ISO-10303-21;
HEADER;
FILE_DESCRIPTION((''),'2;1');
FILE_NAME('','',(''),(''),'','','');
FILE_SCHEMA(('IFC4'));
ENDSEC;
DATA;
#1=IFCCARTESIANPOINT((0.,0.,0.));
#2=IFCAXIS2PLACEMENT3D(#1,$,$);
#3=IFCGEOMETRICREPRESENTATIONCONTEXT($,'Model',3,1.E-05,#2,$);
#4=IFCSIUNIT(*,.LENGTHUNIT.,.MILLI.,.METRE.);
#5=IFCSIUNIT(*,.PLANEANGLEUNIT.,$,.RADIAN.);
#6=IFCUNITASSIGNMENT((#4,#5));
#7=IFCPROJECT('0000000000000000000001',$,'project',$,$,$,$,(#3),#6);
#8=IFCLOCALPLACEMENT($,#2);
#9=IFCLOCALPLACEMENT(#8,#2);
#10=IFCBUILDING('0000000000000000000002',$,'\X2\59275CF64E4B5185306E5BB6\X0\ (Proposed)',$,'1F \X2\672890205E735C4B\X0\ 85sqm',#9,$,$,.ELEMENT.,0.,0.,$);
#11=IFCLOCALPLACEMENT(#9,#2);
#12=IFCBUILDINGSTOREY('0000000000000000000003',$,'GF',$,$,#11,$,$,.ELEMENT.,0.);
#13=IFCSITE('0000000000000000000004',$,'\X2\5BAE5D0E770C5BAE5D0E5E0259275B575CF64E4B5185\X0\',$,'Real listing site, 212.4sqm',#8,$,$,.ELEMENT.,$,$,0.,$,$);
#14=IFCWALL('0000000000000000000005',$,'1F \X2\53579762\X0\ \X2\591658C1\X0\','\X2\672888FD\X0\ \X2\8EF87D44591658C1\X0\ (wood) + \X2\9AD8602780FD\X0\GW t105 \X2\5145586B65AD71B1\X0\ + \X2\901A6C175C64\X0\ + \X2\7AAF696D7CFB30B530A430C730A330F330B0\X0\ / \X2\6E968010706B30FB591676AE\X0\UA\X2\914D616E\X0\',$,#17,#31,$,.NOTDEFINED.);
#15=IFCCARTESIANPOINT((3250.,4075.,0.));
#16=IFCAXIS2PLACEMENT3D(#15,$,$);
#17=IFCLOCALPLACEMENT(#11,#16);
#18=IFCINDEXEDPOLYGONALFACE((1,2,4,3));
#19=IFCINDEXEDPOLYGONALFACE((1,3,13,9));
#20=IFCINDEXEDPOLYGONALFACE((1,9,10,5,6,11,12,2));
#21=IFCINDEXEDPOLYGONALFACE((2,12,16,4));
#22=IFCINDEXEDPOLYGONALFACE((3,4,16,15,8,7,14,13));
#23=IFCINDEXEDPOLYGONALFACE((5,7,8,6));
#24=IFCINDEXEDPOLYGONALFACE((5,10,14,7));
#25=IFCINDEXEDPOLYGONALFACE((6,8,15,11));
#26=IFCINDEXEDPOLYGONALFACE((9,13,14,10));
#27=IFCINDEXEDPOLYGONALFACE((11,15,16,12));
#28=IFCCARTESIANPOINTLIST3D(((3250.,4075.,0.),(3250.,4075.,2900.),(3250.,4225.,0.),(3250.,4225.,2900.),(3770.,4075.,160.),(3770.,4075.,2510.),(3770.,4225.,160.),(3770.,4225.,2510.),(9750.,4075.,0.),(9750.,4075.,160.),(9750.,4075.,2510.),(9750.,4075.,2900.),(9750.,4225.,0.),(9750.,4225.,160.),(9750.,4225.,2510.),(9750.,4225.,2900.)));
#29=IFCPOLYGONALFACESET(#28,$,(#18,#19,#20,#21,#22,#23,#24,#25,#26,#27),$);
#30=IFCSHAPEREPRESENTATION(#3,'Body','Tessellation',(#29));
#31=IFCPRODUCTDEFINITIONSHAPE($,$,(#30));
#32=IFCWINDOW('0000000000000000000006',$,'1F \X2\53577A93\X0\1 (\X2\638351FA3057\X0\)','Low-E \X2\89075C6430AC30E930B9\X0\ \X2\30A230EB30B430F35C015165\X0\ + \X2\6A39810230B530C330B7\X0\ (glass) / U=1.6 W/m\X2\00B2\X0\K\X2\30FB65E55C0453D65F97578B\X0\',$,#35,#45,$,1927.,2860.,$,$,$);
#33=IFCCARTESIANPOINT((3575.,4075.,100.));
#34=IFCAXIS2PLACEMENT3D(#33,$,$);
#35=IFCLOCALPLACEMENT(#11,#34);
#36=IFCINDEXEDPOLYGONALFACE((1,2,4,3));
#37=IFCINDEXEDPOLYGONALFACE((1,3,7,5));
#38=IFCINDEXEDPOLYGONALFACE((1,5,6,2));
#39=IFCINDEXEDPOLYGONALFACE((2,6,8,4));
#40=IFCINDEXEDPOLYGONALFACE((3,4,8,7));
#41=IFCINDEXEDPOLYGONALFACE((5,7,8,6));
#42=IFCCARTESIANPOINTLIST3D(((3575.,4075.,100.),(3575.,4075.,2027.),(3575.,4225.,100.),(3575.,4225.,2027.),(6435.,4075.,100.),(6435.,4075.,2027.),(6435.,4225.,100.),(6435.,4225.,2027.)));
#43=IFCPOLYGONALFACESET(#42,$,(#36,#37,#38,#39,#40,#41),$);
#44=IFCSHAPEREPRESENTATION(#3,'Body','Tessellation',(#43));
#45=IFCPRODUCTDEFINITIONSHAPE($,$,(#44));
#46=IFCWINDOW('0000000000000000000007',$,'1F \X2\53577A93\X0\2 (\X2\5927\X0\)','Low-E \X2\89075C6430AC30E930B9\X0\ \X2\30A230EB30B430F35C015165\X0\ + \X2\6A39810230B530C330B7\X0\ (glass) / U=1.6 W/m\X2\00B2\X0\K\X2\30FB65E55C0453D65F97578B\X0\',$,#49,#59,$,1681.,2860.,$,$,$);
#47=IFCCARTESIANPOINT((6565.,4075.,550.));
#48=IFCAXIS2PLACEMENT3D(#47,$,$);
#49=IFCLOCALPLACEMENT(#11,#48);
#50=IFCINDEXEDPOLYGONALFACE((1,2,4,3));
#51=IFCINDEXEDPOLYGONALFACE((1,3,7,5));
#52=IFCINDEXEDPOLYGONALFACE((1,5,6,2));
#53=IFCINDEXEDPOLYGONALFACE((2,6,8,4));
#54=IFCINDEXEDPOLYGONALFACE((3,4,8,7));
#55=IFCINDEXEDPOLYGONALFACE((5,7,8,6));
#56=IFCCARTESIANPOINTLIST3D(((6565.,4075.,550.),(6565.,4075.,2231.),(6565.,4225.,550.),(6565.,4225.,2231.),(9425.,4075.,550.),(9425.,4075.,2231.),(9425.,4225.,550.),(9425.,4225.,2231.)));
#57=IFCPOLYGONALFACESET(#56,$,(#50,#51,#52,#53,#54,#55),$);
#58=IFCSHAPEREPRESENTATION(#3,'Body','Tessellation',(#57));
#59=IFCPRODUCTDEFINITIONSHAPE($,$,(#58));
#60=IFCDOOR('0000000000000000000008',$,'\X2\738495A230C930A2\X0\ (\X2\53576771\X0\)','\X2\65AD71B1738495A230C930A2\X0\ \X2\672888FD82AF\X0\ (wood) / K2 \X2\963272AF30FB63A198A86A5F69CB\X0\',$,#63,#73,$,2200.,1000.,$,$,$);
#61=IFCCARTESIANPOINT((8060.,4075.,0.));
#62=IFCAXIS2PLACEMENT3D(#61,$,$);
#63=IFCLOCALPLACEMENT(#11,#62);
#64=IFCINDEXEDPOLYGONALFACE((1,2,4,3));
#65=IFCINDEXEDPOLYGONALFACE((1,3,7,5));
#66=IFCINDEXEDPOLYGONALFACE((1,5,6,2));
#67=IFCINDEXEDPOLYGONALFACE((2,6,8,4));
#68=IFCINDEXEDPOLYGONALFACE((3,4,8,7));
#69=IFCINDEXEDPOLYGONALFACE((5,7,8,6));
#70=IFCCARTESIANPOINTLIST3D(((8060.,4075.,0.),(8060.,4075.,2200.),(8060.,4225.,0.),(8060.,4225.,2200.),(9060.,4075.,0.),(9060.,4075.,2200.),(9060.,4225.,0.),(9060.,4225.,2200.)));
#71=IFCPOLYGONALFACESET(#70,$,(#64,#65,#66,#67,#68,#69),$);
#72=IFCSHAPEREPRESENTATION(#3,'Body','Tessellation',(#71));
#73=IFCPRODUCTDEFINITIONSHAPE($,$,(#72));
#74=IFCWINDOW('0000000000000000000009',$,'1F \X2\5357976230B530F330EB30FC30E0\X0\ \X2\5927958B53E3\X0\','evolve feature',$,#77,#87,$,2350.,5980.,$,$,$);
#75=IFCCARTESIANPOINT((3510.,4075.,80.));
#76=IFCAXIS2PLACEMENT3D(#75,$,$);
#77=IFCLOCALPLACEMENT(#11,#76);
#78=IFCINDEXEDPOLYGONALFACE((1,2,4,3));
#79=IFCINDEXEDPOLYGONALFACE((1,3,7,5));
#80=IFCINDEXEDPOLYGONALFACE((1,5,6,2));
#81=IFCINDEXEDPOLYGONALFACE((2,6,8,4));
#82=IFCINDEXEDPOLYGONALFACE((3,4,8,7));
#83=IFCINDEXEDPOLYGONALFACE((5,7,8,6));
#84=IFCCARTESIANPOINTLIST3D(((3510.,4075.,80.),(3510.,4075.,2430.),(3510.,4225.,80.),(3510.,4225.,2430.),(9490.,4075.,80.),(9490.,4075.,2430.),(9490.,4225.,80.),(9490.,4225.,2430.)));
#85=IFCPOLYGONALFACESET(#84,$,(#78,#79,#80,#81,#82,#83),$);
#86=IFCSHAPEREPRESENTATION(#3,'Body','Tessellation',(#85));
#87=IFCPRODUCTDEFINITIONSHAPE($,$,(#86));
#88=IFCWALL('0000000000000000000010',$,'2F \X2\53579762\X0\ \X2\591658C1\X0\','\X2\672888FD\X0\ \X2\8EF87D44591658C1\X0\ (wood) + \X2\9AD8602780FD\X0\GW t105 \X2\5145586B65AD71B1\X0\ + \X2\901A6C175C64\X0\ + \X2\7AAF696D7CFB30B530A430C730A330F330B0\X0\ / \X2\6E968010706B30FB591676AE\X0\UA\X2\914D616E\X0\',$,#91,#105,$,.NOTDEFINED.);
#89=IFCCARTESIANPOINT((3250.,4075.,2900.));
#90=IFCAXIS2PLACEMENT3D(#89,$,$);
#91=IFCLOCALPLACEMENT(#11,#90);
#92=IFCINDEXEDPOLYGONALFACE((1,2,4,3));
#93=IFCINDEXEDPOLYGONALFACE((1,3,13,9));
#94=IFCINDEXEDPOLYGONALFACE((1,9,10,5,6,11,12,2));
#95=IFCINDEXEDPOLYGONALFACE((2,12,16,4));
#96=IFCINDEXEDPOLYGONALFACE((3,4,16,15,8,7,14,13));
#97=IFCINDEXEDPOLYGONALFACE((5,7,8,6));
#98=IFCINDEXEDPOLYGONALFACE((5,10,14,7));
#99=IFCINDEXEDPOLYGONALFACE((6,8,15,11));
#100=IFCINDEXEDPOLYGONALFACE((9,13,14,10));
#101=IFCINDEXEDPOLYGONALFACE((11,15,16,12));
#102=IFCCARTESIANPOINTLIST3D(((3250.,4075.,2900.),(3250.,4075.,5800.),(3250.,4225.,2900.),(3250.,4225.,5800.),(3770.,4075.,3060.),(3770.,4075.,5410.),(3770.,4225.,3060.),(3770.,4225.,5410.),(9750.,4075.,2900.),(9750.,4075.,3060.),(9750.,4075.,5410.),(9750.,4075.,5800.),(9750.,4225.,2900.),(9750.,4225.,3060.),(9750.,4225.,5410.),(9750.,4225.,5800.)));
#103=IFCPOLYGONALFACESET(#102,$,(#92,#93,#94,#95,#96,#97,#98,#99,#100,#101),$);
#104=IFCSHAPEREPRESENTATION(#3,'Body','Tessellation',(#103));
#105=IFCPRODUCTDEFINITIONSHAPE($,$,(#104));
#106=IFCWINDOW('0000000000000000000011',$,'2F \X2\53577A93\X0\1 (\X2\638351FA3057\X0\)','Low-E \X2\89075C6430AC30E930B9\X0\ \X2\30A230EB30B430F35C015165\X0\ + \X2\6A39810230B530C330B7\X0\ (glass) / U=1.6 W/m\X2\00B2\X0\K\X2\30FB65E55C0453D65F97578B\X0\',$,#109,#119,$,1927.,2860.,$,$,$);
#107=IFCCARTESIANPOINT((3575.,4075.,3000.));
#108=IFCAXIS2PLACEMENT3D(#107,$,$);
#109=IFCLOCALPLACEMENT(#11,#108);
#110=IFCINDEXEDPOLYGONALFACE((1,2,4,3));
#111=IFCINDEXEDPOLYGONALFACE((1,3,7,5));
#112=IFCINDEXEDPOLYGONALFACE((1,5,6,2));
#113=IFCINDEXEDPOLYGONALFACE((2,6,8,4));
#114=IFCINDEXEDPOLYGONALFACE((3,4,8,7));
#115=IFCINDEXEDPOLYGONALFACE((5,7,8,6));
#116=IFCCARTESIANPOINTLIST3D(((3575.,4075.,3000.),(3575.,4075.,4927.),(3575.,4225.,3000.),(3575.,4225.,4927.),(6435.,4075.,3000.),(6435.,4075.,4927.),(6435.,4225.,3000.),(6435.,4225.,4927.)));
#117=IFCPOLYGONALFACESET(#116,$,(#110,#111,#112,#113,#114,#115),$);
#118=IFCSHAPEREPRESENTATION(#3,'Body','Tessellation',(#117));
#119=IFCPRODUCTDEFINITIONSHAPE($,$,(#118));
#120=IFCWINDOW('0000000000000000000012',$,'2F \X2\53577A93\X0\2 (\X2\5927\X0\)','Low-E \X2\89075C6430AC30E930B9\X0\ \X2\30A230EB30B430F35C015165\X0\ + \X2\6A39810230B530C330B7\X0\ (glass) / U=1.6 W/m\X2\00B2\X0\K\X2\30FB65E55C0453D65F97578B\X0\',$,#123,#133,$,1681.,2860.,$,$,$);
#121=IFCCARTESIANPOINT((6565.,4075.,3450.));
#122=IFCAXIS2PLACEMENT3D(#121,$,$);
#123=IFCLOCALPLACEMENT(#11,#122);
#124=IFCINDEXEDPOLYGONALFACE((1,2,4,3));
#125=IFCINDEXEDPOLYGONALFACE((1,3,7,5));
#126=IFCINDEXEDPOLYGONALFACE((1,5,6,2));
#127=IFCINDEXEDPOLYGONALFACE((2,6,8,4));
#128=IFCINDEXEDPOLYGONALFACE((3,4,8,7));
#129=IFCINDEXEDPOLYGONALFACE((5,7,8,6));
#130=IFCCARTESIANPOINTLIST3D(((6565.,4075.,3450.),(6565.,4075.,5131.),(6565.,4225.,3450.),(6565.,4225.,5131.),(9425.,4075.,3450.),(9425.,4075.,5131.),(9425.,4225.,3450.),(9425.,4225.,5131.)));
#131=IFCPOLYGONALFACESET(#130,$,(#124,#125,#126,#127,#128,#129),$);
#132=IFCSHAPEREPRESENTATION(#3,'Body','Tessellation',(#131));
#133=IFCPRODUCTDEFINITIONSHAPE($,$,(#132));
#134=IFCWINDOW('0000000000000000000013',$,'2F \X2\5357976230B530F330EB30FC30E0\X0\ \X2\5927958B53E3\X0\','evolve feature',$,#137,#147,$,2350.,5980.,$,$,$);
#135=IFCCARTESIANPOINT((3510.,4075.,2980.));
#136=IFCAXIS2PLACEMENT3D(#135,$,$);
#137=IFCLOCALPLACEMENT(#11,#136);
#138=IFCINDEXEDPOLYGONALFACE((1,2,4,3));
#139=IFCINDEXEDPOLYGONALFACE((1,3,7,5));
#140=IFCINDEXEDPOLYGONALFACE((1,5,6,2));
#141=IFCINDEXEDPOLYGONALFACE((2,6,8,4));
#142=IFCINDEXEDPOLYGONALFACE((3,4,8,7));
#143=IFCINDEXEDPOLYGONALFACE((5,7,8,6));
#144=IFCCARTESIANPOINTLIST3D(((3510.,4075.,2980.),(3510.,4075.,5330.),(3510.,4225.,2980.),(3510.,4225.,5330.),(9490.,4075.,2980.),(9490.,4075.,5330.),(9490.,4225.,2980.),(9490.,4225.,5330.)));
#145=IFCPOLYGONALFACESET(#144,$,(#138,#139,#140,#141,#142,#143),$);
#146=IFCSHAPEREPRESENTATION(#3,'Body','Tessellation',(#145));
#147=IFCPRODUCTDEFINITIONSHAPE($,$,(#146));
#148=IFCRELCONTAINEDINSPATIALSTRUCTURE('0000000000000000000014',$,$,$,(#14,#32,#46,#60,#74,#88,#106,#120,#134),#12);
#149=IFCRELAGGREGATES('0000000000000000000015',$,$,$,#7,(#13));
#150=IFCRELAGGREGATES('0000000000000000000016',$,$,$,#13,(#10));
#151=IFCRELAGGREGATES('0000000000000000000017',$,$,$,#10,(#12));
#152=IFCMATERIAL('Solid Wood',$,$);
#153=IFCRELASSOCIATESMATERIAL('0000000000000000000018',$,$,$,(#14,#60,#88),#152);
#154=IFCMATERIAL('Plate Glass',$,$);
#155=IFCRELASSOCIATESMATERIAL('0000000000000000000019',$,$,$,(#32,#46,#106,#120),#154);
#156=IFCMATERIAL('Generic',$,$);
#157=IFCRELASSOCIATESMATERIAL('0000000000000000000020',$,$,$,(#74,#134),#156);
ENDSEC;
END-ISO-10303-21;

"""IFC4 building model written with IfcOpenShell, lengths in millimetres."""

from ifc_helpers import new_model, si_unit, frame, frame_2d, origin, place, context, project, spatial, rectangle, extrude, material, element, fill, save


model = new_model("IFC4")

# Units and contexts
model_context = context("Model", 3, precision=1e-05, world=origin())
ifc_project = project(units=[si_unit("LENGTHUNIT", "METRE", prefix="MILLI"), si_unit("PLANEANGLEUNIT", "RADIAN")], contexts=[model_context])

# Site, building, storey
site_placement = place(None, origin())
site = spatial("IfcSite", under=ifc_project, at=site_placement, Name="宮崎県宮崎市大字島之内", ObjectType="Real listing site, 212.4sqm", CompositionType="ELEMENT", RefElevation=0.0)
building_placement = place(site_placement, origin())
building = spatial("IfcBuilding", under=site, at=building_placement, Name="大島之内の家 (Proposed)", ObjectType="1F 木造平屋 85sqm", CompositionType="ELEMENT", ElevationOfRefHeight=0.0, ElevationOfTerrain=0.0)
storey_placement = place(building_placement, origin())
storey = spatial("IfcBuildingStorey", under=building, at=storey_placement, Name="GF", CompositionType="ELEMENT", Elevation=0.0)

# Shared definitions
ifc_material_1 = material(Name="Solid Wood")
ifc_material_2 = material(Name="Generic")

# Wall, openings, windows, door
wall_1_placement = place(storey_placement, frame((3250.0, 4075.0, 0.0)))
wall_1 = element("IfcWall", 1, at=wall_1_placement, inside=storey, material=ifc_material_1, Name="1F 南面 外壁", Description="木製 軸組外壁 (wood) + 高性能GW t105 充填断熱 + 通気層 + 窯業系サイディング / 準耐火・外皮UA配慮", PredefinedType="NOTDEFINED", context=model_context, shape_type="SweptSolid", body=[
    extrude(rectangle(XDim=6500.0, YDim=150.0, at=frame_2d((3250.0, 75.0))), frame((3250.0, 4075.0, 0.0)), (0.0, 0.0, 1.0), 2900.0),
])
opening_1_placement = place(storey_placement, frame((3575.0, 4075.0, 100.0)))
opening_1 = element("IfcOpeningElement", 2, at=opening_1_placement, cuts=wall_1, PredefinedType="NOTDEFINED", context=model_context, shape_type="SweptSolid", body=[
    extrude(rectangle(XDim=2860.0, YDim=150.0, at=frame_2d((1430.0, 75.0))), frame((3575.0, 4075.0, 100.0)), (0.0, 0.0, 1.0), 1927.0),
])
opening_2_placement = place(storey_placement, frame((6565.0, 4075.0, 550.0)))
opening_2 = element("IfcOpeningElement", 3, at=opening_2_placement, cuts=wall_1, PredefinedType="NOTDEFINED", context=model_context, shape_type="SweptSolid", body=[
    extrude(rectangle(XDim=2860.0, YDim=150.0, at=frame_2d((1430.0, 75.0))), frame((6565.0, 4075.0, 550.0)), (0.0, 0.0, 1.0), 1681.0),
])
opening_3_placement = place(storey_placement, frame((8060.0, 4075.0, 0.0)))
opening_3 = element("IfcOpeningElement", 4, at=opening_3_placement, cuts=wall_1, PredefinedType="NOTDEFINED", context=model_context, shape_type="SweptSolid", body=[
    extrude(rectangle(XDim=1000.0, YDim=150.0, at=frame_2d((500.0, 75.0))), frame((8060.0, 4075.0, 0.0)), (0.0, 0.0, 1.0), 2200.0),
])
opening_4_placement = place(storey_placement, frame((3510.0, 4075.0, 80.0)))
opening_4 = element("IfcOpeningElement", 5, at=opening_4_placement, cuts=wall_1, PredefinedType="NOTDEFINED", context=model_context, shape_type="SweptSolid", body=[
    extrude(rectangle(XDim=5980.0, YDim=150.0, at=frame_2d((2990.0, 75.0))), frame((3510.0, 4075.0, 80.0)), (0.0, 0.0, 1.0), 2350.0),
])
ifc_material_3 = material(Name="Plate Glass")
window_1_placement = place(storey_placement, frame((3575.0, 4075.0, 100.0)))
window_1 = element("IfcWindow", 6, at=window_1_placement, inside=storey, material=ifc_material_3, Name="1F 南窓1 (掃出し)", Description="Low-E 複層ガラス アルゴン封入 + 樹脂サッシ (glass) / U=1.6 W/m²K・日射取得型", OverallHeight=1927.0, OverallWidth=2860.0, context=model_context, shape_type="SweptSolid", body=[
    extrude(rectangle(XDim=2860.0, YDim=150.0, at=frame_2d((1430.0, 75.0))), frame((3575.0, 4075.0, 100.0)), (0.0, 0.0, 1.0), 1927.0),
])
fill(opening_1, window_1)
window_2_placement = place(storey_placement, frame((6565.0, 4075.0, 550.0)))
window_2 = element("IfcWindow", 7, at=window_2_placement, inside=storey, material=ifc_material_3, Name="1F 南窓2 (大)", Description="Low-E 複層ガラス アルゴン封入 + 樹脂サッシ (glass) / U=1.6 W/m²K・日射取得型", OverallHeight=1681.0, OverallWidth=2860.0, context=model_context, shape_type="SweptSolid", body=[
    extrude(rectangle(XDim=2860.0, YDim=150.0, at=frame_2d((1430.0, 75.0))), frame((6565.0, 4075.0, 550.0)), (0.0, 0.0, 1.0), 1681.0),
])
fill(opening_2, window_2)
door_placement = place(storey_placement, frame((8060.0, 4075.0, 0.0)))
door = element("IfcDoor", 8, at=door_placement, inside=storey, material=ifc_material_1, Name="玄関ドア (南東)", Description="断熱玄関ドア 木製芯 (wood) / K2 防犯・採風機構", OverallHeight=2200.0, OverallWidth=1000.0, context=model_context, shape_type="SweptSolid", body=[
    extrude(rectangle(XDim=1000.0, YDim=150.0, at=frame_2d((500.0, 75.0))), frame((8060.0, 4075.0, 0.0)), (0.0, 0.0, 1.0), 2200.0),
])
fill(opening_3, door)
window_3_placement = place(storey_placement, frame((3510.0, 4075.0, 80.0)))
window_3 = element("IfcWindow", 9, at=window_3_placement, inside=storey, material=ifc_material_2, Name="1F 南面サンルーム 大開口", Description="evolve feature", OverallHeight=2350.0, OverallWidth=5980.0, context=model_context, shape_type="SweptSolid", body=[
    extrude(rectangle(XDim=5980.0, YDim=150.0, at=frame_2d((2990.0, 75.0))), frame((3510.0, 4075.0, 80.0)), (0.0, 0.0, 1.0), 2350.0),
])
fill(opening_4, window_3)

# Wall, openings, windows
wall_2_placement = place(storey_placement, frame((3250.0, 4075.0, 2900.0)))
wall_2 = element("IfcWall", 10, at=wall_2_placement, inside=storey, material=ifc_material_1, Name="2F 南面 外壁", Description="木製 軸組外壁 (wood) + 高性能GW t105 充填断熱 + 通気層 + 窯業系サイディング / 準耐火・外皮UA配慮", PredefinedType="NOTDEFINED", context=model_context, shape_type="SweptSolid", body=[
    extrude(rectangle(XDim=6500.0, YDim=150.0, at=frame_2d((3250.0, 75.0))), frame((3250.0, 4075.0, 2900.0)), (0.0, 0.0, 1.0), 2900.0),
])
opening_5_placement = place(storey_placement, frame((3575.0, 4075.0, 3000.0)))
opening_5 = element("IfcOpeningElement", 11, at=opening_5_placement, cuts=wall_2, PredefinedType="NOTDEFINED", context=model_context, shape_type="SweptSolid", body=[
    extrude(rectangle(XDim=2860.0, YDim=150.0, at=frame_2d((1430.0, 75.0))), frame((3575.0, 4075.0, 3000.0)), (0.0, 0.0, 1.0), 1927.0),
])
opening_6_placement = place(storey_placement, frame((6565.0, 4075.0, 3450.0)))
opening_6 = element("IfcOpeningElement", 12, at=opening_6_placement, cuts=wall_2, PredefinedType="NOTDEFINED", context=model_context, shape_type="SweptSolid", body=[
    extrude(rectangle(XDim=2860.0, YDim=150.0, at=frame_2d((1430.0, 75.0))), frame((6565.0, 4075.0, 3450.0)), (0.0, 0.0, 1.0), 1681.0),
])
opening_7_placement = place(storey_placement, frame((3510.0, 4075.0, 2980.0)))
opening_7 = element("IfcOpeningElement", 13, at=opening_7_placement, cuts=wall_2, PredefinedType="NOTDEFINED", context=model_context, shape_type="SweptSolid", body=[
    extrude(rectangle(XDim=5980.0, YDim=150.0, at=frame_2d((2990.0, 75.0))), frame((3510.0, 4075.0, 2980.0)), (0.0, 0.0, 1.0), 2350.0),
])
window_4_placement = place(storey_placement, frame((3575.0, 4075.0, 3000.0)))
window_4 = element("IfcWindow", 14, at=window_4_placement, inside=storey, material=ifc_material_3, Name="2F 南窓1 (掃出し)", Description="Low-E 複層ガラス アルゴン封入 + 樹脂サッシ (glass) / U=1.6 W/m²K・日射取得型", OverallHeight=1927.0, OverallWidth=2860.0, context=model_context, shape_type="SweptSolid", body=[
    extrude(rectangle(XDim=2860.0, YDim=150.0, at=frame_2d((1430.0, 75.0))), frame((3575.0, 4075.0, 3000.0)), (0.0, 0.0, 1.0), 1927.0),
])
fill(opening_5, window_4)
window_5_placement = place(storey_placement, frame((6565.0, 4075.0, 3450.0)))
window_5 = element("IfcWindow", 15, at=window_5_placement, inside=storey, material=ifc_material_3, Name="2F 南窓2 (大)", Description="Low-E 複層ガラス アルゴン封入 + 樹脂サッシ (glass) / U=1.6 W/m²K・日射取得型", OverallHeight=1681.0, OverallWidth=2860.0, context=model_context, shape_type="SweptSolid", body=[
    extrude(rectangle(XDim=2860.0, YDim=150.0, at=frame_2d((1430.0, 75.0))), frame((6565.0, 4075.0, 3450.0)), (0.0, 0.0, 1.0), 1681.0),
])
fill(opening_6, window_5)
window_6_placement = place(storey_placement, frame((3510.0, 4075.0, 2980.0)))
window_6 = element("IfcWindow", 16, at=window_6_placement, inside=storey, material=ifc_material_2, Name="2F 南面サンルーム 大開口", Description="evolve feature", OverallHeight=2350.0, OverallWidth=5980.0, context=model_context, shape_type="SweptSolid", body=[
    extrude(rectangle(XDim=5980.0, YDim=150.0, at=frame_2d((2990.0, 75.0))), frame((3510.0, 4075.0, 2980.0)), (0.0, 0.0, 1.0), 2350.0),
])
fill(opening_7, window_6)

save(model, "model.ifc")
